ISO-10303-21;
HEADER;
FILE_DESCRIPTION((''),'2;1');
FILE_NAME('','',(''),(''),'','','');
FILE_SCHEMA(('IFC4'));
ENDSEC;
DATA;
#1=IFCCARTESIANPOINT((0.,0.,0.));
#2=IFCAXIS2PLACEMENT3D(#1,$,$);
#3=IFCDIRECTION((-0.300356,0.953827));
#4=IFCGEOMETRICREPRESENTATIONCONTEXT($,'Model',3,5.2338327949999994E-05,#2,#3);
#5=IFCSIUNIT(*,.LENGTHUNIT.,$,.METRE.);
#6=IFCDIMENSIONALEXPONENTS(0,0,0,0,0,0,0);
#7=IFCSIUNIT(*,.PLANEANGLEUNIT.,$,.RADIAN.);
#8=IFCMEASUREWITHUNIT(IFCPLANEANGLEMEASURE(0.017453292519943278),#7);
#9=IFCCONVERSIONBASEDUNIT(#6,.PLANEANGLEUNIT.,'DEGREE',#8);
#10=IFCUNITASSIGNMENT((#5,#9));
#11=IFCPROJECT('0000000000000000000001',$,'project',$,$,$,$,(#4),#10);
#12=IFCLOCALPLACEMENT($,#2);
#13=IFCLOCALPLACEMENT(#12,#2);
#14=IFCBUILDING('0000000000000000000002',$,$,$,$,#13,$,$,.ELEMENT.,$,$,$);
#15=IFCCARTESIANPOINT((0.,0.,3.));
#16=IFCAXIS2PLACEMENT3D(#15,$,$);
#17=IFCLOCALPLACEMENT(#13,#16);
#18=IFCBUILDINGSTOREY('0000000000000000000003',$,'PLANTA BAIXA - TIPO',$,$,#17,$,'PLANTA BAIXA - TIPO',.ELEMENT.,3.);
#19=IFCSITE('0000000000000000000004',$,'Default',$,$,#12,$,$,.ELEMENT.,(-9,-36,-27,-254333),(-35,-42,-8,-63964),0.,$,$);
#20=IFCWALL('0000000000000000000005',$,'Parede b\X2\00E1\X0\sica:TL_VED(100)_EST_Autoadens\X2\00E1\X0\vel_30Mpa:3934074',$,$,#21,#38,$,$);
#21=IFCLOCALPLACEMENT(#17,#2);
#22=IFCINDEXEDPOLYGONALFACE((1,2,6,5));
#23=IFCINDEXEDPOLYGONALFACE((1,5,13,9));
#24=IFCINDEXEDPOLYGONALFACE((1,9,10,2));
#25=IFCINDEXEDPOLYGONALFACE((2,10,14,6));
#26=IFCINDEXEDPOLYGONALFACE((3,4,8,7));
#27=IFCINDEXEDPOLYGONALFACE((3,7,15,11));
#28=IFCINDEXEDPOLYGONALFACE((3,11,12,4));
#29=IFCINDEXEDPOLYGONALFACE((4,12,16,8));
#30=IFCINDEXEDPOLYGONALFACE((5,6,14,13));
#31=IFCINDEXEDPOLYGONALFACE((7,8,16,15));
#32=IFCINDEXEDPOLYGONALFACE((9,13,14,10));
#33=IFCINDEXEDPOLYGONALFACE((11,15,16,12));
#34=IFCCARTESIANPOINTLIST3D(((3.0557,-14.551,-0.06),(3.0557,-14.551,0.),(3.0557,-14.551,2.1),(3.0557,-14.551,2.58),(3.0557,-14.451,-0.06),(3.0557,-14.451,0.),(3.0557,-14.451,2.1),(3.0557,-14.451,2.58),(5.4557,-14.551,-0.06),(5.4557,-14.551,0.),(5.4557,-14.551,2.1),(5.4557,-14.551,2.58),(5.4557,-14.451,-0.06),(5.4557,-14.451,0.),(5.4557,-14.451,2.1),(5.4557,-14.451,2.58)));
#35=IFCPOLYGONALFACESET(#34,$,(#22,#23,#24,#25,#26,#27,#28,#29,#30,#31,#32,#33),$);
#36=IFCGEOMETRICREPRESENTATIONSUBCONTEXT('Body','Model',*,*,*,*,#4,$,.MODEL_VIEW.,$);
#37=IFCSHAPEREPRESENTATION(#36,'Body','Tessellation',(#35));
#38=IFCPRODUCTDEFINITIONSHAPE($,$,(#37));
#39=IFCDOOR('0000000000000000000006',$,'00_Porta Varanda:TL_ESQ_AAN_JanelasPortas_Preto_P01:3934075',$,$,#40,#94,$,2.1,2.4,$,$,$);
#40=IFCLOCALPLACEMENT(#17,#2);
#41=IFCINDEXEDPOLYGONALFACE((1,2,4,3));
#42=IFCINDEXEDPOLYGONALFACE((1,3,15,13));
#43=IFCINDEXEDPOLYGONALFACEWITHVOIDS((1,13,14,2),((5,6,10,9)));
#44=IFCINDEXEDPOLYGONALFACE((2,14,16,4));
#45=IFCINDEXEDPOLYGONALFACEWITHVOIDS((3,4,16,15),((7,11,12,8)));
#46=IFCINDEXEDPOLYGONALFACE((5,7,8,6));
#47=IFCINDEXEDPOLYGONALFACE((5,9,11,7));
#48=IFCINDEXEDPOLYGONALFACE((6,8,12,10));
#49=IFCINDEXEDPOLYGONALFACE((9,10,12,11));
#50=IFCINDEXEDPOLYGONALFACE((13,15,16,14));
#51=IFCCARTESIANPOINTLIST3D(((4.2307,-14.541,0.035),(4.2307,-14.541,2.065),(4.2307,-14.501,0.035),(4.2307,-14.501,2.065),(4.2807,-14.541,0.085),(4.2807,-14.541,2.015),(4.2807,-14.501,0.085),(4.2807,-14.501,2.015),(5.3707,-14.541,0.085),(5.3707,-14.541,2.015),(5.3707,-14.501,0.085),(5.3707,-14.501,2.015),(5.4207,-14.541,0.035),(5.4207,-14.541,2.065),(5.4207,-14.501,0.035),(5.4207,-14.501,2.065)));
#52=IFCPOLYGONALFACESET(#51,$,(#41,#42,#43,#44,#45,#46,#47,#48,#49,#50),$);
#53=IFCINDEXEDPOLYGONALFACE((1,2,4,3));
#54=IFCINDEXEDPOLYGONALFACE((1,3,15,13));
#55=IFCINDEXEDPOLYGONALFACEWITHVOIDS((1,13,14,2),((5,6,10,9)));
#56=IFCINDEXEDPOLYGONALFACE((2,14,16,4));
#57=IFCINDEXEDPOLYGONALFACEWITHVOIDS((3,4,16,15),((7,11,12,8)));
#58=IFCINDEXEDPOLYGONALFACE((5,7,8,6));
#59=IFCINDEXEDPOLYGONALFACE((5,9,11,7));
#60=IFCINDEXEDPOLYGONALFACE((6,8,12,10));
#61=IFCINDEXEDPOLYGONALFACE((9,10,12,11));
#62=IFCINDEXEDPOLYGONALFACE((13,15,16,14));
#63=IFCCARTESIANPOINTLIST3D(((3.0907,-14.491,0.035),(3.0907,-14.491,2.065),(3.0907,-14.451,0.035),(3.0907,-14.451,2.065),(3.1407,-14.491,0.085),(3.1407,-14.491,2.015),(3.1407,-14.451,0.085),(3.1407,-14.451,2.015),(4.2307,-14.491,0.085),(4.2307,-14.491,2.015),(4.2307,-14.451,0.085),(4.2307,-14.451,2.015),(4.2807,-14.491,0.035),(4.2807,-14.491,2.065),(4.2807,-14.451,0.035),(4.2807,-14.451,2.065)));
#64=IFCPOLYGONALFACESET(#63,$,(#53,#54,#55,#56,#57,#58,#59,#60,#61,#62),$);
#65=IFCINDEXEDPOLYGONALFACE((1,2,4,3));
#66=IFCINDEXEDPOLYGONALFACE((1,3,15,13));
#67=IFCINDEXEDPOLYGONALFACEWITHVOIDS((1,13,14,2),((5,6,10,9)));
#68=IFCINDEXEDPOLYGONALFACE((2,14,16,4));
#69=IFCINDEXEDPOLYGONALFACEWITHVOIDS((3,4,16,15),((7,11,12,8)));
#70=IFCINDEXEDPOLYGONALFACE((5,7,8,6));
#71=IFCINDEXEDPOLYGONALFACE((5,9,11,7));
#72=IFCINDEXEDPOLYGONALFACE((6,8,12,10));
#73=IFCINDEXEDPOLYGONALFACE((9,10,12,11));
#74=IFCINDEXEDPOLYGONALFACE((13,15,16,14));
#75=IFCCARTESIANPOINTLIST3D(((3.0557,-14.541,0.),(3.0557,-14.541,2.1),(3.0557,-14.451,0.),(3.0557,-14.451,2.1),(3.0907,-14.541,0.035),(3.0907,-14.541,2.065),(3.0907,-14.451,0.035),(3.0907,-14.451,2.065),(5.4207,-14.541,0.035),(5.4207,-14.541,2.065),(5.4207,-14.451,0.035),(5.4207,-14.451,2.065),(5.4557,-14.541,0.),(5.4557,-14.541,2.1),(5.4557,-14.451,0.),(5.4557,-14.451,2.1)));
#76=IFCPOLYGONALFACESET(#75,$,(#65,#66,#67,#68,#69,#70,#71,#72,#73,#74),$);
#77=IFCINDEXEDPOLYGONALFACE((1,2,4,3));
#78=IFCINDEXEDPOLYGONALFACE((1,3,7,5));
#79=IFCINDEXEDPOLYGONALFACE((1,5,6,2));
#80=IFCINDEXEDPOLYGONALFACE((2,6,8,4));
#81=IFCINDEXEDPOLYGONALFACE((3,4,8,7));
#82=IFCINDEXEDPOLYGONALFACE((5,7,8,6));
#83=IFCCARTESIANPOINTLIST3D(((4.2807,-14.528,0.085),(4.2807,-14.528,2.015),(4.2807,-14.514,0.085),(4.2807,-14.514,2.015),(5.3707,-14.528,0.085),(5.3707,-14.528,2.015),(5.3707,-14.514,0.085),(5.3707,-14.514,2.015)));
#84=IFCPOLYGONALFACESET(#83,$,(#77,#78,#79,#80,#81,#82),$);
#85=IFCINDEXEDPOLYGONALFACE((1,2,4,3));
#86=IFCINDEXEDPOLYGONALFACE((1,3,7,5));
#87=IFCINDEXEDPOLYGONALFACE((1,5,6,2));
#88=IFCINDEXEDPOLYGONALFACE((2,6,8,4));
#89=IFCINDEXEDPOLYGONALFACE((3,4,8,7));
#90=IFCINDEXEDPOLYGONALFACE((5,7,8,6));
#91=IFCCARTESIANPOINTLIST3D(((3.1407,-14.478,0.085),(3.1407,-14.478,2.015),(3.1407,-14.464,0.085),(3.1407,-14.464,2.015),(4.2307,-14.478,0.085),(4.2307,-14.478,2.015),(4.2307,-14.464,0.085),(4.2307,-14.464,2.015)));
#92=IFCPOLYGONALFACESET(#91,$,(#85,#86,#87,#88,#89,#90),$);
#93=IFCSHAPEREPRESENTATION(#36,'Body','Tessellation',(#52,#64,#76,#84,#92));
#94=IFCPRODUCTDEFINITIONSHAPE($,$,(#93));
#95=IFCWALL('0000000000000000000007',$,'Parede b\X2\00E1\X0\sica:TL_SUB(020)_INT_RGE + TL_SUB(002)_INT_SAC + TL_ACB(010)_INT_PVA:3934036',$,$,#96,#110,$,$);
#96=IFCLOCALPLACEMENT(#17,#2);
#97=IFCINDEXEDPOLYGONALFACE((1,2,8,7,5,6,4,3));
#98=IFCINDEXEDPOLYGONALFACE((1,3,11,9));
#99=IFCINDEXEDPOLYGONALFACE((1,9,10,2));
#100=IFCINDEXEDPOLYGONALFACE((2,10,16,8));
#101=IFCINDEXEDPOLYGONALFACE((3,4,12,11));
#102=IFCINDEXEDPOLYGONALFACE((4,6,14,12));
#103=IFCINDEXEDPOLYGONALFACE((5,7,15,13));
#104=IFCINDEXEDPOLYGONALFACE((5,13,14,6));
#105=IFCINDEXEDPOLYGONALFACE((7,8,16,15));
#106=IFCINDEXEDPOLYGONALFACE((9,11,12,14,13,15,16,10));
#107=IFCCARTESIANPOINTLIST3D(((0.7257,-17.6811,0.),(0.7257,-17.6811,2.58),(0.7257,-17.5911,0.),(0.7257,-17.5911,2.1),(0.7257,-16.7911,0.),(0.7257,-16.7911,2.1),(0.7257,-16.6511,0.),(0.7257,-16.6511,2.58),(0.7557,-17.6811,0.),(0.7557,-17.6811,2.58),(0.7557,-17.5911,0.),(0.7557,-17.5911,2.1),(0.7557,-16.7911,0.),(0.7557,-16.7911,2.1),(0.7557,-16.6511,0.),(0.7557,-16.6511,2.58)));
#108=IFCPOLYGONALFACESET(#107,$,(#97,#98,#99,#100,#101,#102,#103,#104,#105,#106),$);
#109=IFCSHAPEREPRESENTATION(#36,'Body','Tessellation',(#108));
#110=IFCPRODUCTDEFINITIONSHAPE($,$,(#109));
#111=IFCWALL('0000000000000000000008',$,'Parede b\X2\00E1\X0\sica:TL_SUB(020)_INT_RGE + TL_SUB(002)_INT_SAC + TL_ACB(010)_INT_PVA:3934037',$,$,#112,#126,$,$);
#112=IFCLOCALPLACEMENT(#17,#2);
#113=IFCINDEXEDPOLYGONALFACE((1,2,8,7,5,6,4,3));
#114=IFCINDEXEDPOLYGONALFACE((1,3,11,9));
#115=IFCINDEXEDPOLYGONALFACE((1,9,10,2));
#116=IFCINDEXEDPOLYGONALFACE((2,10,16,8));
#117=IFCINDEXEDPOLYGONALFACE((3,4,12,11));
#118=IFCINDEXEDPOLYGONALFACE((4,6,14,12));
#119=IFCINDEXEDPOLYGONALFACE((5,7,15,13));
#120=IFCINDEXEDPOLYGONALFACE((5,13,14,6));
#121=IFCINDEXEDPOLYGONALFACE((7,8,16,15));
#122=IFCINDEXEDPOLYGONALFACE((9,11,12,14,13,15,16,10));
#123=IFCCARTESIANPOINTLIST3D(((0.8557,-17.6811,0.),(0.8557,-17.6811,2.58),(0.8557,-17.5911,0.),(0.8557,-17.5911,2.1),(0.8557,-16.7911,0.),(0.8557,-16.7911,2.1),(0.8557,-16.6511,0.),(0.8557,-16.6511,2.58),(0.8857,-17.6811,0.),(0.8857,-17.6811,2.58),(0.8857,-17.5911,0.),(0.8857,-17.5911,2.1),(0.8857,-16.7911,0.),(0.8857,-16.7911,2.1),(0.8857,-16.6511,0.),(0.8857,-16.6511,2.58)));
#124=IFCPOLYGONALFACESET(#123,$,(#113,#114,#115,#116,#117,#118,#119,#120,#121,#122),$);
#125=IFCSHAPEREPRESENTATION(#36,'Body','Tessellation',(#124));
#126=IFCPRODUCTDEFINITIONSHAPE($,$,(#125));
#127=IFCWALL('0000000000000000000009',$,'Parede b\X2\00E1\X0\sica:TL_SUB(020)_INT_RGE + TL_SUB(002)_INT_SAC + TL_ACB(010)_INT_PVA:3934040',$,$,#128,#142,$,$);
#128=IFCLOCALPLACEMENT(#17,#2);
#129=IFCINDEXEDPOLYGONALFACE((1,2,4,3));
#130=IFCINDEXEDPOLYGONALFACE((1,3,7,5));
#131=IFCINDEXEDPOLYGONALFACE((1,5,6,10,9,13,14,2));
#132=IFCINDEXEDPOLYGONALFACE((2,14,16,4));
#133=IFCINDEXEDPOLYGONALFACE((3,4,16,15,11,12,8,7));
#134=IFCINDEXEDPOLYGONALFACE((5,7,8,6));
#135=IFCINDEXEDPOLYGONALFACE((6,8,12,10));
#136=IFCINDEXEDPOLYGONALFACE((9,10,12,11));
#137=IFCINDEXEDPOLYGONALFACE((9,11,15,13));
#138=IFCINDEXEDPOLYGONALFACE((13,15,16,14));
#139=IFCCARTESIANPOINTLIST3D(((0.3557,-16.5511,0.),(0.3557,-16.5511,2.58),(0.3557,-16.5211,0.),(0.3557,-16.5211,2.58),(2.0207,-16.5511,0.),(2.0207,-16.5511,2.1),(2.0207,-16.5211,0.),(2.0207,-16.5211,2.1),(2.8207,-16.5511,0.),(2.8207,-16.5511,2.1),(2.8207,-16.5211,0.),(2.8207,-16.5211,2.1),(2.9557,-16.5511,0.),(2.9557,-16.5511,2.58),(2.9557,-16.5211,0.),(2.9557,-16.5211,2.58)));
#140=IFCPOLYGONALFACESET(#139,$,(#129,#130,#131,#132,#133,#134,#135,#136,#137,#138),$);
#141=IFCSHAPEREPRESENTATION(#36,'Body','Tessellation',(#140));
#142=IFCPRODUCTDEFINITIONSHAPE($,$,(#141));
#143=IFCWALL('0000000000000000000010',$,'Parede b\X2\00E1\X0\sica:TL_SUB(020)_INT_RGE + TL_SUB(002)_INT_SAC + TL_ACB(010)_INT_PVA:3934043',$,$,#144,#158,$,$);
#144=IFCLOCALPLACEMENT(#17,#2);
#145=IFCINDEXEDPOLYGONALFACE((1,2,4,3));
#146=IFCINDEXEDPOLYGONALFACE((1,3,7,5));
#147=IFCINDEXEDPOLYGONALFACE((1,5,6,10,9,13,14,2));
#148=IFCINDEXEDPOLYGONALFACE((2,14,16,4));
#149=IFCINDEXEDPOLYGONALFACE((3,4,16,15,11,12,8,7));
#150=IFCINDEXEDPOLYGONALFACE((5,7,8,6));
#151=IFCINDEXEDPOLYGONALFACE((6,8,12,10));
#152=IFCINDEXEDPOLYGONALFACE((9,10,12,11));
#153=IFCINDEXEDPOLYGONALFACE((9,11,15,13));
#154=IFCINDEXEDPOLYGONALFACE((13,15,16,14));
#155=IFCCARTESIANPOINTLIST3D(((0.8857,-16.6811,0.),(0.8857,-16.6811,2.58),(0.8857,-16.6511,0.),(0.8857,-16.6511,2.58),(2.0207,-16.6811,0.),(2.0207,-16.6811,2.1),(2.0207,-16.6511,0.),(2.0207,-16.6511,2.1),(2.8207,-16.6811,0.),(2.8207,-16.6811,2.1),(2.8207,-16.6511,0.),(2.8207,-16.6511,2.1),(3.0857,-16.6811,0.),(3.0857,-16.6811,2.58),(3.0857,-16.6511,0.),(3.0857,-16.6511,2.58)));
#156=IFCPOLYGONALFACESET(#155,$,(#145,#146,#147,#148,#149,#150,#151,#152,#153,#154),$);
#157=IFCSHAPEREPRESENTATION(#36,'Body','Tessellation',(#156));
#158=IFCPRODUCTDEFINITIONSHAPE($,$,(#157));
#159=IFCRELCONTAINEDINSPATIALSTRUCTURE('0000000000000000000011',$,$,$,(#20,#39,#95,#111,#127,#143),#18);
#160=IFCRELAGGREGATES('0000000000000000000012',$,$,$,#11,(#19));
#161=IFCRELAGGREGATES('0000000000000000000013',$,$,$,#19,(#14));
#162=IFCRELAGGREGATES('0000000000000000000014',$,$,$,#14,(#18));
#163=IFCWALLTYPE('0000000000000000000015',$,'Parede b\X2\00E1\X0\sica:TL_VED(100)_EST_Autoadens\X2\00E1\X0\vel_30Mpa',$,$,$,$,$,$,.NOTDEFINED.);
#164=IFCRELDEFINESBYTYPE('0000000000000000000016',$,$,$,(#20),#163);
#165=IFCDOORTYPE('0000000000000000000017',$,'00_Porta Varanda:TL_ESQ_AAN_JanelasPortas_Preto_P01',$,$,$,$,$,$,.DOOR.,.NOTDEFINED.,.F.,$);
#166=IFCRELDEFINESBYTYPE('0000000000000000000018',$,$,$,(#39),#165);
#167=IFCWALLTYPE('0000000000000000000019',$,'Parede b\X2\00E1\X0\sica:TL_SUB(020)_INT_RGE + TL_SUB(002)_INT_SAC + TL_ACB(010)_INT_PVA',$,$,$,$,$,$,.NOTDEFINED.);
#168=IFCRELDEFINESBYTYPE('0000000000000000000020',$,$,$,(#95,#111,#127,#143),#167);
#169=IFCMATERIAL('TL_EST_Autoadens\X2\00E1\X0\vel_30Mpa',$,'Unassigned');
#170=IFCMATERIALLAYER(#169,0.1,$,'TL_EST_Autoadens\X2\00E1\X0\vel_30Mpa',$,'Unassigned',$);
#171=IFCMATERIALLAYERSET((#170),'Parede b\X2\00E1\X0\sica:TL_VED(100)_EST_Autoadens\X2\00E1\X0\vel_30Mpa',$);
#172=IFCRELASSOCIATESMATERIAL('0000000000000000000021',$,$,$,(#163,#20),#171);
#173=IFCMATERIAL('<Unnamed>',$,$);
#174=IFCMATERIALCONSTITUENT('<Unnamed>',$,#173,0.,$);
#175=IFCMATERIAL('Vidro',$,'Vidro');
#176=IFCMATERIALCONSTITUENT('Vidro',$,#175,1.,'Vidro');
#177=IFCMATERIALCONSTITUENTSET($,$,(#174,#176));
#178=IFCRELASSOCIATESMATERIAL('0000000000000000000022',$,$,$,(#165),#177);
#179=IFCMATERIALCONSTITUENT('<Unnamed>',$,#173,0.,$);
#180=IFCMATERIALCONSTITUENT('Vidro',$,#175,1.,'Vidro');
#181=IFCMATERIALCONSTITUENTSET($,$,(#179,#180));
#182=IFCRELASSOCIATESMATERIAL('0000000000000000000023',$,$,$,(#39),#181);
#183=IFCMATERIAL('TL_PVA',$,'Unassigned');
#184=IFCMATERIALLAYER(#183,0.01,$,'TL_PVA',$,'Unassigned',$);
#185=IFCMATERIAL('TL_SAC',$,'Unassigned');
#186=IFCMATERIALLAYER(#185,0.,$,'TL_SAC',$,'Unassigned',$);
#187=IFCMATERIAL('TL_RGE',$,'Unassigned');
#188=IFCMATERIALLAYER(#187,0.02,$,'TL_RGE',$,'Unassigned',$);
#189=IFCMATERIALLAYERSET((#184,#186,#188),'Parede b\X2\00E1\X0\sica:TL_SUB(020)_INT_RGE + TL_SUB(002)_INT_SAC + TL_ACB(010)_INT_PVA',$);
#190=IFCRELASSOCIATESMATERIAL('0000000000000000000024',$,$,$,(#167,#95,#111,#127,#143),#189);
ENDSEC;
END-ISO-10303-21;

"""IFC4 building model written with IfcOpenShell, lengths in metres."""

from ifc_helpers import new_model, entity, si_unit, converted_unit, direction, frame, frame_2d, origin, place, context, subcontext, project, spatial, polyline, rectangle, outline, extrude, source, transform, mapped, material, layer, layer_set, layer_usage, constituent, constituent_set, type_object, type_shapes, element, fill, save


model = new_model("IFC4")

# Units and contexts
model_context = context("Model", 3, precision=5.2338327949999994e-05, world=origin(), true_north=direction((-0.300356, 0.953827)))
body_context = subcontext(model_context, "Body", "Model", "MODEL_VIEW")
ifc_project = project(units=[si_unit("LENGTHUNIT", "METRE"), converted_unit("PLANEANGLEUNIT", "DEGREE", entity("IfcPlaneAngleMeasure", 0.017453292519943278), si_unit("PLANEANGLEUNIT", "RADIAN"), dimensions=[0, 0, 0, 0, 0, 0, 0])], contexts=[model_context])

# Site, building, storey
site_placement = place(None, origin())
site = spatial("IfcSite", under=ifc_project, at=site_placement, Name="Default", CompositionType="ELEMENT", RefLatitude=(-9, -36, -27, -254333), RefLongitude=(-35, -42, -8, -63964), RefElevation=0.0)
building_placement = place(site_placement, origin())
building = spatial("IfcBuilding", under=site, at=building_placement, CompositionType="ELEMENT")
storey_placement = place(building_placement, frame((0.0, 0.0, 3.0)))
storey = spatial("IfcBuildingStorey", under=building, at=storey_placement, Name="PLANTA BAIXA - TIPO", LongName="PLANTA BAIXA - TIPO", CompositionType="ELEMENT", Elevation=3.0)

# Shared definitions
ifc_material_1 = material(Name="TL_EST_Autoadensável_30Mpa", Category="Unassigned")
ifc_layer_1 = layer(ifc_material_1, 0.1, Name="TL_EST_Autoadensável_30Mpa", Category="Unassigned")
ifc_layer_set_1 = layer_set([ifc_layer_1], Name="Parede básica:TL_VED(100)_EST_Autoadensável_30Mpa")
wall_type_1 = type_object("IfcWallType", Name="Parede básica:TL_VED(100)_EST_Autoadensável_30Mpa", PredefinedType="NOTDEFINED", material=ifc_layer_set_1)

# Wall, opening, door
ifc_layer_usage_1 = layer_usage(ifc_layer_set_1, "AXIS2", "NEGATIVE", 0.05)
wall_1_placement = place(storey_placement, frame((3.0557, -14.501, -0.06)))
wall_1 = element("IfcWall", 1, at=wall_1_placement, inside=storey, type_object=wall_type_1, material=ifc_layer_usage_1, Name="Parede básica:TL_VED(100)_EST_Autoadensável_30Mpa:3934074", context=body_context, shape_type="SweptSolid", body=[
    extrude(rectangle(XDim=2.4, YDim=0.1, at=frame_2d((1.2, 0.0), x_axis=(-1.0, 0.0))), origin(), (0.0, 0.0, 1.0), 2.64),
])
opening_1_placement = place(wall_1_placement, frame((2.4, 0.05, 0.06)))
opening_1 = element("IfcOpeningElement", 2, at=opening_1_placement, cuts=wall_1, PredefinedType="OPENING", context=body_context, shape_type="SweptSolid", body=[
    extrude(rectangle(XDim=2.1, YDim=2.4, at=frame_2d((1.05, 1.2), x_axis=(1.0, 0.0))), frame((0.0, 0.0, 0.0), z_axis=(0.0, -1.0, 0.0), x_axis=(0.0, 0.0, 1.0)), (0.0, 0.0, 1.0), 0.1),
])
ifc_material_2 = material(Name="<Unnamed>")
ifc_constituent_1 = constituent(ifc_material_2, Name="<Unnamed>", fraction=0.0)
ifc_material_3 = material(Name="Vidro", Category="Vidro")
ifc_constituent_2 = constituent(ifc_material_3, Name="Vidro", Category="Vidro", fraction=1.0)
ifc_constituent_set_1 = constituent_set(constituents=[ifc_constituent_1, ifc_constituent_2])
ifc_constituent_3 = constituent(ifc_material_2, Name="<Unnamed>", fraction=0.0)
ifc_constituent_4 = constituent(ifc_material_3, Name="Vidro", Category="Vidro", fraction=1.0)
ifc_constituent_set_2 = constituent_set(constituents=[ifc_constituent_3, ifc_constituent_4])
door_type = type_object("IfcDoorType", Name="00_Porta Varanda:TL_ESQ_AAN_JanelasPortas_Preto_P01", OperationType="NOTDEFINED", ParameterTakesPrecedence=False, PredefinedType="DOOR", material=ifc_constituent_set_2)
shared_shape_1 = source(origin(), body_context, "Body", "SweptSolid", [
    extrude(outline(polyline([(-0.595, -1.015), (0.595, -1.015), (0.595, 1.015), (-0.595, 1.015), (-0.595, -1.015)]), holes=[polyline([(-0.545, 0.965), (0.545, 0.965), (0.545, -0.965), (-0.545, -0.965), (-0.545, 0.965)])]), frame((0.63, 0.09, 1.05), z_axis=(0.0, -1.0, 0.0), x_axis=(-1.0, 0.0, 0.0)), (0.0, 0.0, 1.0), 0.04),
    extrude(outline(polyline([(-0.595, -1.015), (0.595, -1.015), (0.595, 1.015), (-0.595, 1.015), (-0.595, -1.015)]), holes=[polyline([(-0.545, 0.965), (0.545, 0.965), (0.545, -0.965), (-0.545, -0.965), (-0.545, 0.965)])]), frame((1.77, 0.04, 1.05), z_axis=(0.0, -1.0, 0.0), x_axis=(1.0, 0.0, 0.0)), (0.0, 0.0, 1.0), 0.04),
    extrude(outline(polyline([(-1.2, -1.05), (1.2, -1.05), (1.2, 1.05), (-1.2, 1.05), (-1.2, -1.05)]), holes=[polyline([(-1.165, 1.015), (1.165, 1.015), (1.165, -1.015), (-1.165, -1.015), (-1.165, 1.015)])]), frame((1.2, 0.09, 1.05), z_axis=(0.0, -1.0, 0.0), x_axis=(1.0, 0.0, 0.0)), (0.0, 0.0, 1.0), 0.09),
    extrude(rectangle(XDim=1.09, YDim=0.014, at=frame_2d((0.0, 0.0), x_axis=(1.0, 0.0))), frame((0.63, 0.07, 0.085), z_axis=(0.0, 0.0, 1.0), x_axis=(-1.0, 0.0, 0.0)), (0.0, 0.0, 1.0), 1.93),
    extrude(rectangle(XDim=1.09, YDim=0.014, at=frame_2d((0.0, 0.0), x_axis=(1.0, 0.0))), frame((1.77, 0.02, 0.085), z_axis=(0.0, 0.0, 1.0), x_axis=(-1.0, 0.0, 0.0)), (0.0, 0.0, 1.0), 1.93),
])
type_shapes(door_type, [shared_shape_1])
door_placement = place(opening_1_placement, frame((0.0, 0.0, 0.0), z_axis=(0.0, 0.0, 1.0), x_axis=(-1.0, 0.0, 0.0)))
door = element("IfcDoor", 3, at=door_placement, inside=storey, type_object=door_type, material=ifc_constituent_set_1, Name="00_Porta Varanda:TL_ESQ_AAN_JanelasPortas_Preto_P01:3934075", OverallHeight=2.1, OverallWidth=2.4, context=body_context, shape_type="MappedRepresentation", body=[
    mapped(shared_shape_1, transform((0.0, 0.0, 0.0), scale=1.0)),
])
fill(opening_1, door)

# Walls, openings
ifc_material_4 = material(Name="TL_PVA", Category="Unassigned")
ifc_layer_2 = layer(ifc_material_4, 0.01, Name="TL_PVA", Category="Unassigned")
ifc_material_5 = material(Name="TL_SAC", Category="Unassigned")
ifc_layer_3 = layer(ifc_material_5, 0.0, Name="TL_SAC", Category="Unassigned")
ifc_material_6 = material(Name="TL_RGE", Category="Unassigned")
ifc_layer_4 = layer(ifc_material_6, 0.02, Name="TL_RGE", Category="Unassigned")
ifc_layer_set_2 = layer_set([ifc_layer_2, ifc_layer_3, ifc_layer_4], Name="Parede básica:TL_SUB(020)_INT_RGE + TL_SUB(002)_INT_SAC + TL_ACB(010)_INT_PVA")
ifc_layer_usage_2 = layer_usage(ifc_layer_set_2, "AXIS2", "POSITIVE", -0.015)
wall_type_2 = type_object("IfcWallType", Name="Parede básica:TL_SUB(020)_INT_RGE + TL_SUB(002)_INT_SAC + TL_ACB(010)_INT_PVA", PredefinedType="NOTDEFINED", material=ifc_layer_set_2)
wall_2_placement = place(storey_placement, frame((0.7407, -16.6511, 0.0), z_axis=(0.0, 0.0, 1.0), x_axis=(0.0, -1.0, 0.0)))
wall_2 = element("IfcWall", 4, at=wall_2_placement, inside=storey, type_object=wall_type_2, material=ifc_layer_usage_2, Name="Parede básica:TL_SUB(020)_INT_RGE + TL_SUB(002)_INT_SAC + TL_ACB(010)_INT_PVA:3934036", context=body_context, shape_type="SweptSolid", body=[
    extrude(rectangle(XDim=1.03, YDim=0.03, at=frame_2d((0.515, 0.0), x_axis=(1.0, 0.0))), origin(), (0.0, 0.0, 1.0), 2.58),
])
opening_2_placement = place(wall_2_placement, frame((-16.6511, -0.7407, 0.0)))
element("IfcOpeningElement", 5, at=opening_2_placement, cuts=wall_2, PredefinedType="OPENING", context=body_context, shape_type="SweptSolid", body=[
    extrude(rectangle(XDim=2.1, YDim=0.8, at=frame_2d((0.0, 0.0), x_axis=(0.0, 1.0))), frame((17.1911, -0.6683, 1.05), z_axis=(0.0, 1.0, 0.0), x_axis=(-1.0, 0.0, 0.0)), (0.0, 0.0, 1.0), 3.048),
])
ifc_layer_usage_3 = layer_usage(ifc_layer_set_2, "AXIS2", "POSITIVE", -0.015)
wall_3_placement = place(storey_placement, frame((0.8707, -17.6811, 0.0), z_axis=(0.0, 0.0, 1.0), x_axis=(0.0, 1.0, 0.0)))
wall_3 = element("IfcWall", 6, at=wall_3_placement, inside=storey, type_object=wall_type_2, material=ifc_layer_usage_3, Name="Parede básica:TL_SUB(020)_INT_RGE + TL_SUB(002)_INT_SAC + TL_ACB(010)_INT_PVA:3934037", context=body_context, shape_type="SweptSolid", body=[
    extrude(rectangle(XDim=1.03, YDim=0.03, at=frame_2d((0.515, 0.0), x_axis=(1.0, 0.0))), origin(), (0.0, 0.0, 1.0), 2.58),
])
opening_3_placement = place(wall_3_placement, frame((17.6811, 0.8707, 0.0)))
element("IfcOpeningElement", 7, at=opening_3_placement, cuts=wall_3, PredefinedType="OPENING", context=body_context, shape_type="SweptSolid", body=[
    extrude(rectangle(XDim=2.1, YDim=0.8, at=frame_2d((0.0, 0.0), x_axis=(1.0, 0.0))), frame((-17.1911, -2.3797, 1.05), z_axis=(0.0, 1.0, 0.0), x_axis=(0.0, 0.0, 1.0)), (0.0, 0.0, 1.0), 3.048),
])
ifc_layer_usage_4 = layer_usage(ifc_layer_set_2, "AXIS2", "POSITIVE", -0.015)
wall_4_placement = place(storey_placement, frame((2.9557, -16.5361, 0.0), z_axis=(0.0, 0.0, 1.0), x_axis=(-1.0, 0.0, 0.0)))
wall_4 = element("IfcWall", 8, at=wall_4_placement, inside=storey, type_object=wall_type_2, material=ifc_layer_usage_4, Name="Parede básica:TL_SUB(020)_INT_RGE + TL_SUB(002)_INT_SAC + TL_ACB(010)_INT_PVA:3934040", context=body_context, shape_type="SweptSolid", body=[
    extrude(rectangle(XDim=2.6, YDim=0.03, at=frame_2d((1.3, 0.0), x_axis=(-1.0, 0.0))), origin(), (0.0, 0.0, 1.0), 2.58),
])
opening_4_placement = place(wall_4_placement, frame((2.9557, -16.5361, 0.0)))
element("IfcOpeningElement", 9, at=opening_4_placement, cuts=wall_4, PredefinedType="OPENING", context=body_context, shape_type="SweptSolid", body=[
    extrude(rectangle(XDim=2.1, YDim=0.8, at=frame_2d((0.0, 0.0), x_axis=(1.0, 0.0))), frame((-2.4207, 15.1271, 1.05), z_axis=(0.0, 1.0, 0.0), x_axis=(0.0, 0.0, 1.0)), (0.0, 0.0, 1.0), 3.048),
])
ifc_layer_usage_5 = layer_usage(ifc_layer_set_2, "AXIS2", "POSITIVE", -0.015)
wall_5_placement = place(storey_placement, frame((0.8857, -16.6661, 0.0)))
wall_5 = element("IfcWall", 10, at=wall_5_placement, inside=storey, type_object=wall_type_2, material=ifc_layer_usage_5, Name="Parede básica:TL_SUB(020)_INT_RGE + TL_SUB(002)_INT_SAC + TL_ACB(010)_INT_PVA:3934043", context=body_context, shape_type="SweptSolid", body=[
    extrude(rectangle(XDim=2.2, YDim=0.03, at=frame_2d((1.1, 0.0), x_axis=(-1.0, 0.0))), origin(), (0.0, 0.0, 1.0), 2.58),
])
opening_5_placement = place(wall_5_placement, frame((-0.8857, 16.6661, 0.0)))
element("IfcOpeningElement", 11, at=opening_5_placement, cuts=wall_5, PredefinedType="OPENING", context=body_context, shape_type="SweptSolid", body=[
    extrude(rectangle(XDim=2.1, YDim=0.8, at=frame_2d((0.0, 0.0), x_axis=(0.0, 1.0))), frame((2.4207, -18.1751, 1.05), z_axis=(0.0, 1.0, 0.0), x_axis=(-1.0, 0.0, 0.0)), (0.0, 0.0, 1.0), 3.048),
])

save(model, "model.ifc")
